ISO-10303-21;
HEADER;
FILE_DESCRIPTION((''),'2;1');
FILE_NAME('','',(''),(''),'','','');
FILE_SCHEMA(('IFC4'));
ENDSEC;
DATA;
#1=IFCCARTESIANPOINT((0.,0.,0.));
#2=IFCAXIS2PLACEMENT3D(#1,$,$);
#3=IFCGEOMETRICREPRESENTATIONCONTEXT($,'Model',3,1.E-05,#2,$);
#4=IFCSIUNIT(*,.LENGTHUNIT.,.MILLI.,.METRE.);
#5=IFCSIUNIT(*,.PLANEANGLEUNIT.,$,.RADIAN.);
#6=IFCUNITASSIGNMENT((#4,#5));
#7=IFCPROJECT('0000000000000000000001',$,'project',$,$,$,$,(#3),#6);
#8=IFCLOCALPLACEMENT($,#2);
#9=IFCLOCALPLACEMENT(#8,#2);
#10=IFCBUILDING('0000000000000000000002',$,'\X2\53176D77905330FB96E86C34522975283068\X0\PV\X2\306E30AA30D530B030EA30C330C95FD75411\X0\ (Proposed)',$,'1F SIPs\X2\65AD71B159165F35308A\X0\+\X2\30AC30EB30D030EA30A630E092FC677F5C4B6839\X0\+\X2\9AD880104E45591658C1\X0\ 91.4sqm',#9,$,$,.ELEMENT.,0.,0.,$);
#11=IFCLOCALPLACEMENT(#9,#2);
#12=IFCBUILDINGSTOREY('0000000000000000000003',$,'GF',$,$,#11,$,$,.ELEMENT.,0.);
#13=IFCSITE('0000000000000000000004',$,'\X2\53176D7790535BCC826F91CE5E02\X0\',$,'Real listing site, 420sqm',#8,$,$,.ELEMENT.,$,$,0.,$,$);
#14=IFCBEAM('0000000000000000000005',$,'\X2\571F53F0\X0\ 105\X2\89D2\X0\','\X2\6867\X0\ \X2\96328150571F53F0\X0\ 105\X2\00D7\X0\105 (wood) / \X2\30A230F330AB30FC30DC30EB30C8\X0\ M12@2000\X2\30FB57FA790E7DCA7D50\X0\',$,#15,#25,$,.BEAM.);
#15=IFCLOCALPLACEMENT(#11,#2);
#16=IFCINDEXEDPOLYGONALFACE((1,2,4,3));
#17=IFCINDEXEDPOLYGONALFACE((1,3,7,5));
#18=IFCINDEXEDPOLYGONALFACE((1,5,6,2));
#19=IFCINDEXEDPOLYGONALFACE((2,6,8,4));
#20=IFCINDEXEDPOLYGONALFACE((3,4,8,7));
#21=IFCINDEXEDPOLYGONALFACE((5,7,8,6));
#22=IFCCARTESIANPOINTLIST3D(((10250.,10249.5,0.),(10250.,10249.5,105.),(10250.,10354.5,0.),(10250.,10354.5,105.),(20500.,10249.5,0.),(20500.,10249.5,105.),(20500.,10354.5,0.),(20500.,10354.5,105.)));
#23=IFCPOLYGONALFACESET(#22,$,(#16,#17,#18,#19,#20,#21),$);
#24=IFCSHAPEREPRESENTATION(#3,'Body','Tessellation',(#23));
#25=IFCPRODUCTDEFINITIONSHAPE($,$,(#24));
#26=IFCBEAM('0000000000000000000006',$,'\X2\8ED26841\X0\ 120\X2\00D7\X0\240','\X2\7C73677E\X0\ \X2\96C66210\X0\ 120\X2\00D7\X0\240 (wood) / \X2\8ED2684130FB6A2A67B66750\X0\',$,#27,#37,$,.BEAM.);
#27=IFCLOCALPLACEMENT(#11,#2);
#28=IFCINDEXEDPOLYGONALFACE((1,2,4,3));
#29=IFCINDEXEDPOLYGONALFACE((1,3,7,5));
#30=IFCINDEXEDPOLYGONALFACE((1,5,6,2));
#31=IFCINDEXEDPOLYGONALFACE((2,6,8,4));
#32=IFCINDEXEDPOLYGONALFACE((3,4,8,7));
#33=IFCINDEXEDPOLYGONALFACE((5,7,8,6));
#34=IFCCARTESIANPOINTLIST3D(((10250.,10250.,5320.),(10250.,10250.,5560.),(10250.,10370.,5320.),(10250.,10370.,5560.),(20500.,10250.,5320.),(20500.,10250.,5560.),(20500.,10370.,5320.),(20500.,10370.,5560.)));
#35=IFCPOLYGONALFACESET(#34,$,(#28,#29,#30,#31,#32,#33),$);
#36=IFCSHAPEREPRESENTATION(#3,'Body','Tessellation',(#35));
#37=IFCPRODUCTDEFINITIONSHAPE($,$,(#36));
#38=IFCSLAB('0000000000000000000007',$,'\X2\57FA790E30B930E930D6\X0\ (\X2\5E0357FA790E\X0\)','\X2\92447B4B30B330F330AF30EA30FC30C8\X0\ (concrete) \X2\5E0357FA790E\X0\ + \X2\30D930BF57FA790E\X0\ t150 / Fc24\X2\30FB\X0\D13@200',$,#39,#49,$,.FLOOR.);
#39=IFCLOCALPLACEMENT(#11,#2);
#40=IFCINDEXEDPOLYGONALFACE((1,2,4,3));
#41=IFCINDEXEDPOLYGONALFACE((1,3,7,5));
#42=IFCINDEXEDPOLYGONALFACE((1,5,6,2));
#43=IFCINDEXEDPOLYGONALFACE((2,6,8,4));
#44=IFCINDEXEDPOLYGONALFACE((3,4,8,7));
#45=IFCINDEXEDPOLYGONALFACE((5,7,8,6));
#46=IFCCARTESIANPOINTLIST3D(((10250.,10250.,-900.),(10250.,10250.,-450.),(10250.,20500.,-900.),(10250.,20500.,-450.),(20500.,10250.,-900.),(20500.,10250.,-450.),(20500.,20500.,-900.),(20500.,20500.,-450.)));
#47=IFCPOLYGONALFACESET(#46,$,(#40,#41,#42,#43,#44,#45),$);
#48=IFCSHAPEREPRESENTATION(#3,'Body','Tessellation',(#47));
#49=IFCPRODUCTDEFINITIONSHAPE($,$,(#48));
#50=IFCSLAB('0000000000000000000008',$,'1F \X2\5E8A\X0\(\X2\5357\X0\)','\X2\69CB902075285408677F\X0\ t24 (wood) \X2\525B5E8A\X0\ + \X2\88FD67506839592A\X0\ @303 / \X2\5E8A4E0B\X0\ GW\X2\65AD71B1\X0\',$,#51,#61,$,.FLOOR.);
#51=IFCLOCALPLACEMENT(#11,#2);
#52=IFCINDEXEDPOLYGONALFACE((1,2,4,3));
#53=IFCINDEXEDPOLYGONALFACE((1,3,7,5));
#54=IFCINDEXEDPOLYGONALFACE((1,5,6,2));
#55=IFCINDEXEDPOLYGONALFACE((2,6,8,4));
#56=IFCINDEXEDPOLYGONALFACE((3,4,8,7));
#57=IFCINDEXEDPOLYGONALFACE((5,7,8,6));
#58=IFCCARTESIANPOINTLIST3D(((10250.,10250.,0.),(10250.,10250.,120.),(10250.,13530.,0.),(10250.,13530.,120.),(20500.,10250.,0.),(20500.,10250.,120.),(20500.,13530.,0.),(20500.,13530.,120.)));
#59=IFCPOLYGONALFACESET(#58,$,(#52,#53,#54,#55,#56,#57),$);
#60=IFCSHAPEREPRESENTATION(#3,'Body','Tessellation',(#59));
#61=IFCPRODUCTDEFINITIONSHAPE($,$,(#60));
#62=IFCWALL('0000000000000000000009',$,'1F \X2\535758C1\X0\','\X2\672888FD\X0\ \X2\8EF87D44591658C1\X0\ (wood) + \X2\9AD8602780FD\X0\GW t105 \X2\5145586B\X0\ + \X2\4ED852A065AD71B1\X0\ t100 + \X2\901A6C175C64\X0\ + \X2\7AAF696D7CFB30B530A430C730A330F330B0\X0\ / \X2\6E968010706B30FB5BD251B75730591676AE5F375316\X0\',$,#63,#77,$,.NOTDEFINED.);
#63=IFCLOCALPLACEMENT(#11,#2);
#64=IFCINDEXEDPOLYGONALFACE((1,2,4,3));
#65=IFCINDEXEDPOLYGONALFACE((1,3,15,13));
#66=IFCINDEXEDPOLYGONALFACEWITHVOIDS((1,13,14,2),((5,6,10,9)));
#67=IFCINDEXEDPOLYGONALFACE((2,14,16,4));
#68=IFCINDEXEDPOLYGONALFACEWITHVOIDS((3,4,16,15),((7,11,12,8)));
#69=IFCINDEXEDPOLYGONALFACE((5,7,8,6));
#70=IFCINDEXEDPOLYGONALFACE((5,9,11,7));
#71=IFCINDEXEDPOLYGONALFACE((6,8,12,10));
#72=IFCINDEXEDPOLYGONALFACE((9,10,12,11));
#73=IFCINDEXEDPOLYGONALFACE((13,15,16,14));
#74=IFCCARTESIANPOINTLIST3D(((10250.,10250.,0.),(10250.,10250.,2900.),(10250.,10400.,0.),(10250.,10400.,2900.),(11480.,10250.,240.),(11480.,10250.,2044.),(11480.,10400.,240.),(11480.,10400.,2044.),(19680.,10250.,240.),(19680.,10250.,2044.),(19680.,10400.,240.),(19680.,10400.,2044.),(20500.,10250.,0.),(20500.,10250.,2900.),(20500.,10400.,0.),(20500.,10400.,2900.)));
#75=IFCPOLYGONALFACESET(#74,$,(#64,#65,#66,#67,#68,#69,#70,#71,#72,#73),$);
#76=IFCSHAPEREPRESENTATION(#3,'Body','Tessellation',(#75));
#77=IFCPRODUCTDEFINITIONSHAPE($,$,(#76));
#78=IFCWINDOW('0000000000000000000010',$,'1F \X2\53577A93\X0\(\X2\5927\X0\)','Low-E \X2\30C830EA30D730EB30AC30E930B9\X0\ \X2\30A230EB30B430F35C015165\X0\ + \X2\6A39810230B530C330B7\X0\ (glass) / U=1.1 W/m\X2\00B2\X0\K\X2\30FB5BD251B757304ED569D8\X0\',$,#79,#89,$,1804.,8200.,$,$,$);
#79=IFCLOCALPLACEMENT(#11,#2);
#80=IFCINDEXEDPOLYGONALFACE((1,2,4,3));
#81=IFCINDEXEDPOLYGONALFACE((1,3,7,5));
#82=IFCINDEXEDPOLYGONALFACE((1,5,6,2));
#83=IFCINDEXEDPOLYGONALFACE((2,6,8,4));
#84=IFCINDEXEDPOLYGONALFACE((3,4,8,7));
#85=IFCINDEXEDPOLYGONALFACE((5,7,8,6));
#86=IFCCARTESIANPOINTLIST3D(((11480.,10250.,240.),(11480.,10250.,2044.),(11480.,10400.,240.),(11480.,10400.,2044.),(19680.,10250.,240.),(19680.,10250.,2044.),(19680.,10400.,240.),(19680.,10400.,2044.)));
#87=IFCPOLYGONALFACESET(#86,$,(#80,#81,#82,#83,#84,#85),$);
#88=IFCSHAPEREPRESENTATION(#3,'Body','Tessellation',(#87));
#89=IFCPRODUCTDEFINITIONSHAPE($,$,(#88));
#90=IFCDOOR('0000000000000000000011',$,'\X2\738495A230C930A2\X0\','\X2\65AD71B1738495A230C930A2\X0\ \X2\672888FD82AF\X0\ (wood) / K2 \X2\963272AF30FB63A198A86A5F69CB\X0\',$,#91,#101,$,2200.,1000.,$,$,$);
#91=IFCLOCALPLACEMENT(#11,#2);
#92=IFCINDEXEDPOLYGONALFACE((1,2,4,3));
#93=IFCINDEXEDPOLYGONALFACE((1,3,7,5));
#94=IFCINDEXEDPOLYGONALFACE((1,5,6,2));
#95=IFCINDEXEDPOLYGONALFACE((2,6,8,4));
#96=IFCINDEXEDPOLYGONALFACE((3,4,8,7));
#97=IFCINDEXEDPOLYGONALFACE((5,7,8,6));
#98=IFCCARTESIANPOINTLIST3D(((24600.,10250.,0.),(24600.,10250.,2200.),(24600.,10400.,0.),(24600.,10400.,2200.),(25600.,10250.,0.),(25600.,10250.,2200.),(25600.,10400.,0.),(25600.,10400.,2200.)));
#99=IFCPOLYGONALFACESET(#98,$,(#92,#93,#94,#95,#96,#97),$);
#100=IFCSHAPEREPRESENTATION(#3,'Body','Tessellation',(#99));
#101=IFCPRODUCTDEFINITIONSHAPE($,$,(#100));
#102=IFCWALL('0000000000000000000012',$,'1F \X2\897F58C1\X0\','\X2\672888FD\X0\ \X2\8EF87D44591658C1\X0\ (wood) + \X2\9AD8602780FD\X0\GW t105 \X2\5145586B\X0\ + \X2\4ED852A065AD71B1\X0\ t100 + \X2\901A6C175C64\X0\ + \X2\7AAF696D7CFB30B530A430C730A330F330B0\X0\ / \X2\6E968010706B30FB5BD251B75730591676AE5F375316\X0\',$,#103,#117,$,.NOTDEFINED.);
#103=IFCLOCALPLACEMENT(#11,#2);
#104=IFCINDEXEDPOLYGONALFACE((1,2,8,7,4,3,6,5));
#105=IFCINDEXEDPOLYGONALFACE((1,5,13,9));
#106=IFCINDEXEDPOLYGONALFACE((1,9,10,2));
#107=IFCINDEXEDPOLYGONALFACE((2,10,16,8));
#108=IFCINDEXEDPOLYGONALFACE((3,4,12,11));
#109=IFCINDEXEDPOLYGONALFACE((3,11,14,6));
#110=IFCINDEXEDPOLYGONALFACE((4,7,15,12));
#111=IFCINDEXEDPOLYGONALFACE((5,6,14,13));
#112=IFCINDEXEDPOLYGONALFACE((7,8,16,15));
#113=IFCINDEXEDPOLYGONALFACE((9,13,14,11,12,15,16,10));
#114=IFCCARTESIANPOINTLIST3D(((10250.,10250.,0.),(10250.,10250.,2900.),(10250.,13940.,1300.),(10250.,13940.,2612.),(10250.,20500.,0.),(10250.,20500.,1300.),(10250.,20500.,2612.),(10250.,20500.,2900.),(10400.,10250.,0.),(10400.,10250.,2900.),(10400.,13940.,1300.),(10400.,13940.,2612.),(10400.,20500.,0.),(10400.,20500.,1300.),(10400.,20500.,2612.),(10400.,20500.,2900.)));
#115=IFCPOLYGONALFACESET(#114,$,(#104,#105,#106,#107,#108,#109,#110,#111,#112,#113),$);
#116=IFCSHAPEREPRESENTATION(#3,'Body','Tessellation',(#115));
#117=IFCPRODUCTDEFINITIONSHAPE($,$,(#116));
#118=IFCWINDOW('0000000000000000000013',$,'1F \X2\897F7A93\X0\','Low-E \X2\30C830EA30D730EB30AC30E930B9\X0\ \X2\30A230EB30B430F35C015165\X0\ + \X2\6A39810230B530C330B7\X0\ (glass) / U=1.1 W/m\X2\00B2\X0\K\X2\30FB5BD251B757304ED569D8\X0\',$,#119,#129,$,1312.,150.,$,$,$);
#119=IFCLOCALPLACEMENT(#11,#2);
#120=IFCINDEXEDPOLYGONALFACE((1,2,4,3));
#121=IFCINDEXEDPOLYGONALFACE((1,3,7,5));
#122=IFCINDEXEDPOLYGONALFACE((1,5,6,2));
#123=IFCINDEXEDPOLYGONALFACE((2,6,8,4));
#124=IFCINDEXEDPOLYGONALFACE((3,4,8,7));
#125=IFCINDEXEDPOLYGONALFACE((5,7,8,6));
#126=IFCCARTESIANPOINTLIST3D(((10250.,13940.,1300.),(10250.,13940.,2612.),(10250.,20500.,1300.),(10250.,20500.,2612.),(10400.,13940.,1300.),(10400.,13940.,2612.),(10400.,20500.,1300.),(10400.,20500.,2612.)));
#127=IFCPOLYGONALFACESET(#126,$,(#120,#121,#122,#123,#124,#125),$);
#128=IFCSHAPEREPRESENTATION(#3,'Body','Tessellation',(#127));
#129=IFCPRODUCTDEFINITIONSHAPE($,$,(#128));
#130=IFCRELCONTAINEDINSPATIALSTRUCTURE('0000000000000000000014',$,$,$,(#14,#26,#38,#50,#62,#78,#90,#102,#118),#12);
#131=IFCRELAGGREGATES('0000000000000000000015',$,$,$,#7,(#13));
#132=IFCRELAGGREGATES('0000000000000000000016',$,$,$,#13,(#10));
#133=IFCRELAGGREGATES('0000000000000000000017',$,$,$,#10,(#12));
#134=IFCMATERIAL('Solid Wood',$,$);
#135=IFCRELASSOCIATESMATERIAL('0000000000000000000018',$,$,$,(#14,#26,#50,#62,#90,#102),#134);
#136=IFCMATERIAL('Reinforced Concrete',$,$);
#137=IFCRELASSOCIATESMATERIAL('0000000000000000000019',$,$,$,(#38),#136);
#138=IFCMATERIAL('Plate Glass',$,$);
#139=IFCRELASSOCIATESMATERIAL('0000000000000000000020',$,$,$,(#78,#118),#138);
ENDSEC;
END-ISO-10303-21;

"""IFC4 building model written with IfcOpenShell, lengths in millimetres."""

from ifc_helpers import new_model, si_unit, frame, frame_2d, origin, place, context, project, spatial, rectangle, extrude, material, element, fill, save


model = new_model("IFC4")

# Units and contexts
model_context = context("Model", 3, precision=1e-05, world=origin())
ifc_project = project(units=[si_unit("LENGTHUNIT", "METRE", prefix="MILLI"), si_unit("PLANEANGLEUNIT", "RADIAN")], contexts=[model_context])

# Site, building, storey
site_placement = place(None, origin())
site = spatial("IfcSite", under=ifc_project, at=site_placement, Name="北海道富良野市", ObjectType="Real listing site, 420sqm", CompositionType="ELEMENT", RefElevation=0.0)
building_placement = place(site_placement, origin())
building = spatial("IfcBuilding", under=site, at=building_placement, Name="北海道・雨水利用とPVのオフグリッド志向 (Proposed)", ObjectType="1F SIPs断熱外張り+ガルバリウム鋼板屋根+高耐久外壁 91.4sqm", CompositionType="ELEMENT", ElevationOfRefHeight=0.0, ElevationOfTerrain=0.0)
storey_placement = place(building_placement, origin())
storey = spatial("IfcBuildingStorey", under=building, at=storey_placement, Name="GF", CompositionType="ELEMENT", Elevation=0.0)

# Shared definitions
ifc_material_1 = material(Name="Solid Wood")

# Beams
beam_1_placement = place(storey_placement, frame((5125.0, 5125.0, 0.0)))
element("IfcBeam", 1, at=beam_1_placement, inside=storey, material=ifc_material_1, Name="土台 105角", Description="桧 防腐土台 105×105 (wood) / アンカーボルト M12@2000・基礎緊結", PredefinedType="BEAM", context=model_context, shape_type="SweptSolid", body=[
    extrude(rectangle(XDim=10250.0, YDim=105.0, at=frame_2d((5125.0, 52.0))), frame((5125.0, 5125.0, 0.0)), (0.0, 0.0, 1.0), 105.0),
])
beam_2_placement = place(storey_placement, frame((5125.0, 5125.0, 2660.0)))
element("IfcBeam", 2, at=beam_2_placement, inside=storey, material=ifc_material_1, Name="軒桁 120×240", Description="米松 集成 120×240 (wood) / 軒桁・横架材", PredefinedType="BEAM", context=model_context, shape_type="SweptSolid", body=[
    extrude(rectangle(XDim=10250.0, YDim=120.0, at=frame_2d((5125.0, 60.0))), frame((5125.0, 5125.0, 2660.0)), (0.0, 0.0, 1.0), 240.0),
])

# Slabs
ifc_material_2 = material(Name="Reinforced Concrete")
slab_1_placement = place(storey_placement, frame((5125.0, 5125.0, -450.0)))
element("IfcSlab", 3, at=slab_1_placement, inside=storey, material=ifc_material_2, Name="基礎スラブ (布基礎)", Description="鉄筋コンクリート (concrete) 布基礎 + ベタ基礎 t150 / Fc24・D13@200", PredefinedType="FLOOR", context=model_context, shape_type="SweptSolid", body=[
    extrude(rectangle(XDim=10250.0, YDim=10250.0, at=frame_2d((5125.0, 5125.0))), frame((5125.0, 5125.0, -450.0)), (0.0, 0.0, 1.0), 450.0),
])
slab_2_placement = place(storey_placement, frame((5125.0, 5125.0, 0.0)))
element("IfcSlab", 4, at=slab_2_placement, inside=storey, material=ifc_material_1, Name="1F 床(南)", Description="構造用合板 t24 (wood) 剛床 + 製材根太 @303 / 床下 GW断熱", PredefinedType="FLOOR", context=model_context, shape_type="SweptSolid", body=[
    extrude(rectangle(XDim=10250.0, YDim=3280.0, at=frame_2d((5125.0, 1640.0))), frame((5125.0, 5125.0, 0.0)), (0.0, 0.0, 1.0), 120.0),
])

# Wall, openings, window, door
wall_1_placement = place(storey_placement, frame((5125.0, 5125.0, 0.0)))
wall_1 = element("IfcWall", 5, at=wall_1_placement, inside=storey, material=ifc_material_1, Name="1F 南壁", Description="木製 軸組外壁 (wood) + 高性能GW t105 充填 + 付加断熱 t100 + 通気層 + 窯業系サイディング / 準耐火・寒冷地外皮強化", PredefinedType="NOTDEFINED", context=model_context, shape_type="SweptSolid", body=[
    extrude(rectangle(XDim=10250.0, YDim=150.0, at=frame_2d((5125.0, 75.0))), frame((5125.0, 5125.0, 0.0)), (0.0, 0.0, 1.0), 2900.0),
])
opening_1_placement = place(storey_placement, frame((5740.0, 5125.0, 120.0)))
opening_1 = element("IfcOpeningElement", 6, at=opening_1_placement, cuts=wall_1, PredefinedType="NOTDEFINED", context=model_context, shape_type="SweptSolid", body=[
    extrude(rectangle(XDim=8200.0, YDim=150.0, at=frame_2d((4100.0, 75.0))), frame((5740.0, 5125.0, 120.0)), (0.0, 0.0, 1.0), 1804.0),
])
opening_2_placement = place(storey_placement, frame((12300.0, 5125.0, 0.0)))
opening_2 = element("IfcOpeningElement", 7, at=opening_2_placement, cuts=wall_1, PredefinedType="NOTDEFINED", context=model_context, shape_type="SweptSolid", body=[
    extrude(rectangle(XDim=1000.0, YDim=150.0, at=frame_2d((500.0, 75.0))), frame((12300.0, 5125.0, 0.0)), (0.0, 0.0, 1.0), 2200.0),
])
ifc_material_3 = material(Name="Plate Glass")
window_1_placement = place(storey_placement, frame((5740.0, 5125.0, 120.0)))
window_1 = element("IfcWindow", 8, at=window_1_placement, inside=storey, material=ifc_material_3, Name="1F 南窓(大)", Description="Low-E トリプルガラス アルゴン封入 + 樹脂サッシ (glass) / U=1.1 W/m²K・寒冷地仕様", OverallHeight=1804.0, OverallWidth=8200.0, context=model_context, shape_type="SweptSolid", body=[
    extrude(rectangle(XDim=8200.0, YDim=150.0, at=frame_2d((4100.0, 75.0))), frame((5740.0, 5125.0, 120.0)), (0.0, 0.0, 1.0), 1804.0),
])
fill(opening_1, window_1)
door_placement = place(storey_placement, frame((12300.0, 5125.0, 0.0)))
door = element("IfcDoor", 9, at=door_placement, inside=storey, material=ifc_material_1, Name="玄関ドア", Description="断熱玄関ドア 木製芯 (wood) / K2 防犯・採風機構", OverallHeight=2200.0, OverallWidth=1000.0, context=model_context, shape_type="SweptSolid", body=[
    extrude(rectangle(XDim=1000.0, YDim=150.0, at=frame_2d((500.0, 75.0))), frame((12300.0, 5125.0, 0.0)), (0.0, 0.0, 1.0), 2200.0),
])
fill(opening_2, door)

# Wall, opening, window
wall_2_placement = place(storey_placement, frame((5125.0, 5125.0, 0.0)))
wall_2 = element("IfcWall", 10, at=wall_2_placement, inside=storey, material=ifc_material_1, Name="1F 西壁", Description="木製 軸組外壁 (wood) + 高性能GW t105 充填 + 付加断熱 t100 + 通気層 + 窯業系サイディング / 準耐火・寒冷地外皮強化", PredefinedType="NOTDEFINED", context=model_context, shape_type="SweptSolid", body=[
    extrude(rectangle(XDim=150.0, YDim=10250.0, at=frame_2d((75.0, 5125.0))), frame((5125.0, 5125.0, 0.0)), (0.0, 0.0, 1.0), 2900.0),
])
opening_3_placement = place(storey_placement, frame((5125.0, 6970.0, 650.0)))
opening_3 = element("IfcOpeningElement", 11, at=opening_3_placement, cuts=wall_2, PredefinedType="NOTDEFINED", context=model_context, shape_type="SweptSolid", body=[
    extrude(rectangle(XDim=150.0, YDim=6560.0, at=frame_2d((75.0, 3280.0))), frame((5125.0, 6970.0, 650.0)), (0.0, 0.0, 1.0), 1312.0),
])
window_2_placement = place(storey_placement, frame((5125.0, 6970.0, 650.0)))
window_2 = element("IfcWindow", 12, at=window_2_placement, inside=storey, material=ifc_material_3, Name="1F 西窓", Description="Low-E トリプルガラス アルゴン封入 + 樹脂サッシ (glass) / U=1.1 W/m²K・寒冷地仕様", OverallHeight=1312.0, OverallWidth=150.0, context=model_context, shape_type="SweptSolid", body=[
    extrude(rectangle(XDim=150.0, YDim=6560.0, at=frame_2d((75.0, 3280.0))), frame((5125.0, 6970.0, 650.0)), (0.0, 0.0, 1.0), 1312.0),
])
fill(opening_3, window_2)

save(model, "model.ifc")
